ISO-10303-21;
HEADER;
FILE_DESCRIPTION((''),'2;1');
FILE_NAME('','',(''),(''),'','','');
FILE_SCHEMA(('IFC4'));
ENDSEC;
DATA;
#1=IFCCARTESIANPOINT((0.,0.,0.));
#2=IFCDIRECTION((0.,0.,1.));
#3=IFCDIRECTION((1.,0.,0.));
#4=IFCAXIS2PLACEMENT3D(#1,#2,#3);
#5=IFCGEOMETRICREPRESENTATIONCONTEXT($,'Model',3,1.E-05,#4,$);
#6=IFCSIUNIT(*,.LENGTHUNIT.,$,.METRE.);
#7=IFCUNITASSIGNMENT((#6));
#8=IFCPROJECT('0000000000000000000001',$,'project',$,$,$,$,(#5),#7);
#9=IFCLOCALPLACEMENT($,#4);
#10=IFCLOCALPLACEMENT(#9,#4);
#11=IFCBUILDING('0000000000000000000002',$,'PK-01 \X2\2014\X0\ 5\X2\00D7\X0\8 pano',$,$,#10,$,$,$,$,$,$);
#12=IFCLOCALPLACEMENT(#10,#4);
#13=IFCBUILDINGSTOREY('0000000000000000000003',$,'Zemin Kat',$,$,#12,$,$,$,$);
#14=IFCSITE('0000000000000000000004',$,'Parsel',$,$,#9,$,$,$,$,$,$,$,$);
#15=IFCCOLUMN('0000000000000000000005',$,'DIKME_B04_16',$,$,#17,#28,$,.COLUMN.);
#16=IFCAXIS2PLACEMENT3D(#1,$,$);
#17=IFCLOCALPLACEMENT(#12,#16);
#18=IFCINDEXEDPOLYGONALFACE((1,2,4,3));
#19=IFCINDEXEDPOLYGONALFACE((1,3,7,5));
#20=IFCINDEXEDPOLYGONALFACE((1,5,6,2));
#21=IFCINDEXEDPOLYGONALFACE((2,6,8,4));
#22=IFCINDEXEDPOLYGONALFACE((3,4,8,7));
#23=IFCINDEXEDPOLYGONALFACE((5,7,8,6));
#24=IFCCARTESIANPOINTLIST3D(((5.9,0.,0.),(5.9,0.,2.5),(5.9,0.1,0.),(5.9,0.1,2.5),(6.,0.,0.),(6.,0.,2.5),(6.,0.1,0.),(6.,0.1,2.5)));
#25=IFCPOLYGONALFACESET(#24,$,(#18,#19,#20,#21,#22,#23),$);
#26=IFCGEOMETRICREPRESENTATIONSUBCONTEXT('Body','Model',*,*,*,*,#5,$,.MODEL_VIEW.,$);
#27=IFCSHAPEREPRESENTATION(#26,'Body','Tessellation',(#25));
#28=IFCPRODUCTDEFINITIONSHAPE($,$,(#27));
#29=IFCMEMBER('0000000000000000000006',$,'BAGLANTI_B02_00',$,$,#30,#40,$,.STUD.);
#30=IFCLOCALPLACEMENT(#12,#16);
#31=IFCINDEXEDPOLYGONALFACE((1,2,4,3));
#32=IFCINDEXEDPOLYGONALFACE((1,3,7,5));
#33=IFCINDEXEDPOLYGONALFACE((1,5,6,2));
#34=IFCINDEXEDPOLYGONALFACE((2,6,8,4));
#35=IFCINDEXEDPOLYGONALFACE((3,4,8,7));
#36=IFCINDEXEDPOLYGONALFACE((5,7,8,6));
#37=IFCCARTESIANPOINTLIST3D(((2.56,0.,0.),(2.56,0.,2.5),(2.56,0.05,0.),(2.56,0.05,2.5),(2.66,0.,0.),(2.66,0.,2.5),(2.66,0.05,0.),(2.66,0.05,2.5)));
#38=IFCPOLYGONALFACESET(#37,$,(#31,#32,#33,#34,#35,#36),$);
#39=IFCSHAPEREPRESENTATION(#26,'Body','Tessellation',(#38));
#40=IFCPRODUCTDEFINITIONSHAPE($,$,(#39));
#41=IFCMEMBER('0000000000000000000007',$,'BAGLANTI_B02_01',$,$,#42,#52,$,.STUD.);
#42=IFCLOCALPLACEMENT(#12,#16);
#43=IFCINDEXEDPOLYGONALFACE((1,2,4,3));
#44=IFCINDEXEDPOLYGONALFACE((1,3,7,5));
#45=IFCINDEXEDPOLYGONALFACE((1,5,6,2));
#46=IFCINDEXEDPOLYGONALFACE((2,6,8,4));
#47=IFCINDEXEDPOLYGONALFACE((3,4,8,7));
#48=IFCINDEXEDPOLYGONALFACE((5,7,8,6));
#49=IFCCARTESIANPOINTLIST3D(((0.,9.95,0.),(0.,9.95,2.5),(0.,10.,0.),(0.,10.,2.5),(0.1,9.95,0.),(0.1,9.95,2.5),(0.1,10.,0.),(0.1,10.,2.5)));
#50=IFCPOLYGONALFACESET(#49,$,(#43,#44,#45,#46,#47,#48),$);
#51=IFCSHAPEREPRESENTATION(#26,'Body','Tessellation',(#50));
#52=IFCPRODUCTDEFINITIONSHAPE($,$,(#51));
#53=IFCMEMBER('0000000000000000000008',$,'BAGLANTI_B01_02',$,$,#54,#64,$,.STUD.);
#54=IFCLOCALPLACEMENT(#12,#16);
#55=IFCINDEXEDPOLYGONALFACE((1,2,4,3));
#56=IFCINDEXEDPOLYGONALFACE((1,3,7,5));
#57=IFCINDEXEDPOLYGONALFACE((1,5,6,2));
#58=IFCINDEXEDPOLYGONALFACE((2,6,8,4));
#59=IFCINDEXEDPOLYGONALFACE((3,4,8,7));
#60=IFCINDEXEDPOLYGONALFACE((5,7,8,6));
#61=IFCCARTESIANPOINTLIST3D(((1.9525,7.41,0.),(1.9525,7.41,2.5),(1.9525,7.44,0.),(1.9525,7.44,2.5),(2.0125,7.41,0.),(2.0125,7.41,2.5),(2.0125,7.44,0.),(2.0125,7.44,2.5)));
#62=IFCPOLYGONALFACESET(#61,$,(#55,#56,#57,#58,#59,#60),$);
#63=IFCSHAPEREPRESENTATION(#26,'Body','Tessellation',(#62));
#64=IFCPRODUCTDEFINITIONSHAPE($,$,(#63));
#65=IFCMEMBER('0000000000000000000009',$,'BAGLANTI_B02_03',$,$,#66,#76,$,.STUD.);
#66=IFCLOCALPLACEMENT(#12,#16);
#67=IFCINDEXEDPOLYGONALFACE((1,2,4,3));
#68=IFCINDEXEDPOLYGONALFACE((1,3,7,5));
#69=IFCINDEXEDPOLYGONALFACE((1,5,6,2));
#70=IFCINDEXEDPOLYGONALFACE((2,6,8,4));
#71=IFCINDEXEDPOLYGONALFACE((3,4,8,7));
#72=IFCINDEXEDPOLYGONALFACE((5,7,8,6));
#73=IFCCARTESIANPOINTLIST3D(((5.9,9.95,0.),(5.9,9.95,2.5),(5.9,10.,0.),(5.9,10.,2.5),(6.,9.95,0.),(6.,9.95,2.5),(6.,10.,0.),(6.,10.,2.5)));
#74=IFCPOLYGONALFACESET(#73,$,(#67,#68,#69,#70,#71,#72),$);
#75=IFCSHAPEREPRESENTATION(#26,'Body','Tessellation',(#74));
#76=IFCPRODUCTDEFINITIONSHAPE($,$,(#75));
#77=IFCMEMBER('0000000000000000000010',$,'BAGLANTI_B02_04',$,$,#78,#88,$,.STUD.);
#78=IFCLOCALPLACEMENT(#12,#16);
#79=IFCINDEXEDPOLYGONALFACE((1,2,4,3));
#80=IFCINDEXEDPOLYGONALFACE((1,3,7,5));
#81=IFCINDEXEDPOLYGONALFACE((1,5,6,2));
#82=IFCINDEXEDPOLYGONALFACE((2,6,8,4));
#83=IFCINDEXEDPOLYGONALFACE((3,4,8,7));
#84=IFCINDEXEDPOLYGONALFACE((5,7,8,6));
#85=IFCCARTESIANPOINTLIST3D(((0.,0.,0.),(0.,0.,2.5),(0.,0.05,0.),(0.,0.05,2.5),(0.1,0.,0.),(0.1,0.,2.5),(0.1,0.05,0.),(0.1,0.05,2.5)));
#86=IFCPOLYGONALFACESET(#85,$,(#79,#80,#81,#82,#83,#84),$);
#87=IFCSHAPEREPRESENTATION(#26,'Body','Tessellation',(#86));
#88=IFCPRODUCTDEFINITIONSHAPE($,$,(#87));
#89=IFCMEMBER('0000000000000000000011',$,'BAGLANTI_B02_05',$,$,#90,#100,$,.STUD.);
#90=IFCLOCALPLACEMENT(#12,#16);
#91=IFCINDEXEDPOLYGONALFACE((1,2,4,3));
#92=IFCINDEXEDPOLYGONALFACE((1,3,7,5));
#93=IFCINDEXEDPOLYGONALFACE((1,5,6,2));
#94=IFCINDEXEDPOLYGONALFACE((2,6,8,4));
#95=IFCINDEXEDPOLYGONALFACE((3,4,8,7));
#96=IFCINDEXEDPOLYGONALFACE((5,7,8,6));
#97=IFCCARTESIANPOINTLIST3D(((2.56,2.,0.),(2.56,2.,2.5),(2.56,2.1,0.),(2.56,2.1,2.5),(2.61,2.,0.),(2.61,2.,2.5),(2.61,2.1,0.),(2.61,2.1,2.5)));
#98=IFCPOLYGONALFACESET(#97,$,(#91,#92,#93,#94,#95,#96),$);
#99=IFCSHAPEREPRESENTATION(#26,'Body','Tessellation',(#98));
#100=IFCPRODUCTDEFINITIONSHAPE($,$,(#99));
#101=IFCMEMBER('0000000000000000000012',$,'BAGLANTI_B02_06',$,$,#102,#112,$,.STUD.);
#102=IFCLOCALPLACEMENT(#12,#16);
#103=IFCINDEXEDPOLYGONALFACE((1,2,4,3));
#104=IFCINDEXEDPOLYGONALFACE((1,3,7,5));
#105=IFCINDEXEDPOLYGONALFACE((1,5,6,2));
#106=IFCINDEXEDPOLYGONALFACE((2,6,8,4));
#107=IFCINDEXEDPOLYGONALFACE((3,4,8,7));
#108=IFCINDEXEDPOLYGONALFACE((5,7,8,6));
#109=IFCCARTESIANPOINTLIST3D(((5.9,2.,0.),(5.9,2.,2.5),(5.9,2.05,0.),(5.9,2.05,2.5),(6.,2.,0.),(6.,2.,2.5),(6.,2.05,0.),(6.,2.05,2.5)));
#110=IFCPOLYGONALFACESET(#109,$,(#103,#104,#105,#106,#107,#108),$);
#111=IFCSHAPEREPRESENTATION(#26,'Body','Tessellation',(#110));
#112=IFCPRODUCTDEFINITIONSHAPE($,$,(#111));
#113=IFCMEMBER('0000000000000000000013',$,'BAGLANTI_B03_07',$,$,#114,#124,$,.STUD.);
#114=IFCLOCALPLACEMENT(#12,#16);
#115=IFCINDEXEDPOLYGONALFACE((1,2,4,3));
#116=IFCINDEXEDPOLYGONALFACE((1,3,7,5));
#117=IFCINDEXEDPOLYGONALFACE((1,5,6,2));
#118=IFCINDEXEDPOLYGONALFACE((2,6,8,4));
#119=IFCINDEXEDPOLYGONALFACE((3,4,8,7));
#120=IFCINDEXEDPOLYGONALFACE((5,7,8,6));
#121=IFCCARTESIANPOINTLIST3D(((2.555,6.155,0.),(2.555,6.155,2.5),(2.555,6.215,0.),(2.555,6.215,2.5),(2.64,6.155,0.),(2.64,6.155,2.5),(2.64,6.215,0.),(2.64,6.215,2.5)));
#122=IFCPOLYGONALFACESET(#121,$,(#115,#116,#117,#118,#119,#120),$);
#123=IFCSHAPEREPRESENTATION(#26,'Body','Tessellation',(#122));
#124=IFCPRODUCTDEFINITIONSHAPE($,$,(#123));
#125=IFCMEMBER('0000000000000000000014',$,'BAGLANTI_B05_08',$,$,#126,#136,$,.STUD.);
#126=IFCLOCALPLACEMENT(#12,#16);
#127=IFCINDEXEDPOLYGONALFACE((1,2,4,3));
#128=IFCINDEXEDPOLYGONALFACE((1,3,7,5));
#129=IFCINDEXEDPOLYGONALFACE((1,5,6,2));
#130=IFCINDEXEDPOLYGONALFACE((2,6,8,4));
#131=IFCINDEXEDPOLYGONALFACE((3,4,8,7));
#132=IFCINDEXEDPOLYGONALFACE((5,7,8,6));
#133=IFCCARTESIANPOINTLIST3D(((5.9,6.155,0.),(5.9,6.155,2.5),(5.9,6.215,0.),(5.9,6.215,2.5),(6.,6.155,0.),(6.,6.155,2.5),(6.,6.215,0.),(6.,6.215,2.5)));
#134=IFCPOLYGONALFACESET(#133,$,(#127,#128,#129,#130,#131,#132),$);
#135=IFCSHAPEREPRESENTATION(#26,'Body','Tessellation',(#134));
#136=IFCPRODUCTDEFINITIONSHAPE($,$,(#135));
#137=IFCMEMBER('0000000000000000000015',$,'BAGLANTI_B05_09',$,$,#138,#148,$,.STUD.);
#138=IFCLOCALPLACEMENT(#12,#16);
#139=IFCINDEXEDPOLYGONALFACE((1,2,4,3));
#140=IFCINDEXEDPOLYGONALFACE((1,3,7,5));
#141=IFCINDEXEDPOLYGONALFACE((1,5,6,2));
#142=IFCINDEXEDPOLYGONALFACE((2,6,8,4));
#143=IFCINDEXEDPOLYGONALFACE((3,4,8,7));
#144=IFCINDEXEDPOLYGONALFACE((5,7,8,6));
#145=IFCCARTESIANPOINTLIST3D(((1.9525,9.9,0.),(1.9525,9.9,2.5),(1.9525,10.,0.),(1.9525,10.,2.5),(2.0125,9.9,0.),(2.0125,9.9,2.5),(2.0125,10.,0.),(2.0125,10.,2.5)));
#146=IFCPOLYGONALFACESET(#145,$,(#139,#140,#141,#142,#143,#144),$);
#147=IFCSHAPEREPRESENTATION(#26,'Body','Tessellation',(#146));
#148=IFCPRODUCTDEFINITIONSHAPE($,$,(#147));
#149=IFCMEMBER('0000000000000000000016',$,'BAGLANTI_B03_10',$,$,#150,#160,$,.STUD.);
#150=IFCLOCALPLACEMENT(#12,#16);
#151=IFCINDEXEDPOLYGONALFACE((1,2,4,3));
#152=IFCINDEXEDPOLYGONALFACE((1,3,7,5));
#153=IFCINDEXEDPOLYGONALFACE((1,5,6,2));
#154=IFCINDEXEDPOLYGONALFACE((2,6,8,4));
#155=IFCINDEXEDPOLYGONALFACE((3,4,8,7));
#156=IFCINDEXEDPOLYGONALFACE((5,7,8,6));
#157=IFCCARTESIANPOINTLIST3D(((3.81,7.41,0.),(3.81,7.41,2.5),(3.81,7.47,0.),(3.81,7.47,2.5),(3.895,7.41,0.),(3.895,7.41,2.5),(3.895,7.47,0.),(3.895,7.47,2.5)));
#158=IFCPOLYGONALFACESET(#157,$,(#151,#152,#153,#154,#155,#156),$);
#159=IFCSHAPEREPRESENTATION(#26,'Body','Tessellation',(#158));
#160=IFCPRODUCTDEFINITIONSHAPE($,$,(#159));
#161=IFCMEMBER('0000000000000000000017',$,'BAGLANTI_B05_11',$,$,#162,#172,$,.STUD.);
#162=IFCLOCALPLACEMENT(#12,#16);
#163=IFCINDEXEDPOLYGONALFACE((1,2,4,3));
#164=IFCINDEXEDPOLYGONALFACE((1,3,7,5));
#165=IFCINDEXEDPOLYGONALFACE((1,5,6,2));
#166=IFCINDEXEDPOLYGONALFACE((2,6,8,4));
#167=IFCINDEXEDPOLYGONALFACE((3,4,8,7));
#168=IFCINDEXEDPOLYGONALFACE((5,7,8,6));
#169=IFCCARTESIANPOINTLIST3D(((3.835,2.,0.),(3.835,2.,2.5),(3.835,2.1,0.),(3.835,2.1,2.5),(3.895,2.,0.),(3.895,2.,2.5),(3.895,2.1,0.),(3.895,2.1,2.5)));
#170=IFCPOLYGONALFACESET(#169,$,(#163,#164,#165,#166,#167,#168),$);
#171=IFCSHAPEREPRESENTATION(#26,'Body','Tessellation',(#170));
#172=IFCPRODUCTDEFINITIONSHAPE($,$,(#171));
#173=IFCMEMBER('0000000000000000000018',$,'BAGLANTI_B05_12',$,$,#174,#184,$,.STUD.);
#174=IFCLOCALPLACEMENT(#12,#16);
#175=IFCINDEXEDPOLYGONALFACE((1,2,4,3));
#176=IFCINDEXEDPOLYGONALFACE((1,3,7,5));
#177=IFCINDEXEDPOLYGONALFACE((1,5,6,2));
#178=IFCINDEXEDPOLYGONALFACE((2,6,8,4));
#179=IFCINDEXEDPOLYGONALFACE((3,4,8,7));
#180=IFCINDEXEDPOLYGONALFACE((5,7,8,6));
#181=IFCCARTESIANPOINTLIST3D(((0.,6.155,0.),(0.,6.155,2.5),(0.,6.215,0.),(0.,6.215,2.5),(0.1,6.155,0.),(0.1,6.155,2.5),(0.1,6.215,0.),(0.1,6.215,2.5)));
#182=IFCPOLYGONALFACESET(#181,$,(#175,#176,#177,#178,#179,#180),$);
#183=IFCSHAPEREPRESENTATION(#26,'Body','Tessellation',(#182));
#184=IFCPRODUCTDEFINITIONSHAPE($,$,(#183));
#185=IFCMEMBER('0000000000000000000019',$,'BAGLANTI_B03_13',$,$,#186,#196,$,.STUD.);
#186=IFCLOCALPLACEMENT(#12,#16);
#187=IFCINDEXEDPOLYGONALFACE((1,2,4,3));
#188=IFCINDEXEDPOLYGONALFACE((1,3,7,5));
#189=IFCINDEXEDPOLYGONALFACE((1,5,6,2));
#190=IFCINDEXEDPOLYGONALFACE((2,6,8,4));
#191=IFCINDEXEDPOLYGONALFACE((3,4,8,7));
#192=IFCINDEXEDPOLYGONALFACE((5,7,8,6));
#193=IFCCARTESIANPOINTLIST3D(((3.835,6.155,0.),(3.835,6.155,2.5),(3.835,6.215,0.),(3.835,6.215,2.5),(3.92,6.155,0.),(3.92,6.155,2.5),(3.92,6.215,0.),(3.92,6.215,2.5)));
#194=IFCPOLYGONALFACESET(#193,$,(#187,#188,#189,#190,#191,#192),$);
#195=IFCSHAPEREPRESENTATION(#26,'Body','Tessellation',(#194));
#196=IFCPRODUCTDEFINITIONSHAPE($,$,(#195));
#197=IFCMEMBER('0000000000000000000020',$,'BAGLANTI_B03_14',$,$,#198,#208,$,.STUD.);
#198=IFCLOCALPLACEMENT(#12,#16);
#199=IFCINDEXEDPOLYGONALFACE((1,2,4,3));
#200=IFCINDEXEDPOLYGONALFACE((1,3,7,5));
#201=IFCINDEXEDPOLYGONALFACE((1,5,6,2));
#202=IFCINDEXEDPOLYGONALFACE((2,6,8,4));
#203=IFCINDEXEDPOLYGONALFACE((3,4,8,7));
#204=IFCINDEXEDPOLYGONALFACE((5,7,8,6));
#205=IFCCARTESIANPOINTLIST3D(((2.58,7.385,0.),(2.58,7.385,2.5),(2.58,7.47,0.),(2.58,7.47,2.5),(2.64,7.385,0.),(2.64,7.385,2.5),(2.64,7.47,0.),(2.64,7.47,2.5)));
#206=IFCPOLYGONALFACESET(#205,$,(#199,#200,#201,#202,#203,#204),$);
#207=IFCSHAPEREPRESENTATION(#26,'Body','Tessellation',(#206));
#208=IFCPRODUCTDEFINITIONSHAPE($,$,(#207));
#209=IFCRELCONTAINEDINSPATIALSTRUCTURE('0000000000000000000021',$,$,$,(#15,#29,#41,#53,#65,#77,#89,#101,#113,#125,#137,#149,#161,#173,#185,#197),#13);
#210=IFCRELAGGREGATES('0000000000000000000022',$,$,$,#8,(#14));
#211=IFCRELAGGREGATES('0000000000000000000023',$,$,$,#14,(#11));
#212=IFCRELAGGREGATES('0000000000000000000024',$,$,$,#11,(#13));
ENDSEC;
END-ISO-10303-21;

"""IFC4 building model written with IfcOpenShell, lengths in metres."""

from ifc_helpers import new_model, si_unit, origin_with_axes, place, context, subcontext, project, spatial, line, indexed_curve, outline, extrude, element, save


model = new_model("IFC4")

# Units and contexts
model_context = context("Model", 3, precision=1e-05, world=origin_with_axes())
body_context = subcontext(model_context, "Body", "Model", "MODEL_VIEW")
ifc_project = project(units=[si_unit("LENGTHUNIT", "METRE")], contexts=[model_context])

# Site, building, storey
site_placement = place(None, origin_with_axes())
site = spatial("IfcSite", under=ifc_project, at=site_placement, Name="Parsel")
building_placement = place(site_placement, origin_with_axes())
building = spatial("IfcBuilding", under=site, at=building_placement, Name="PK-01 — 5×8 pano")
storey_placement = place(building_placement, origin_with_axes())
storey = spatial("IfcBuildingStorey", under=building, at=storey_placement, Name="Zemin Kat")

# Column
column_placement = place(storey_placement, origin_with_axes())
element("IfcColumn", 1, at=column_placement, inside=storey, Name="DIKME_B04_16", PredefinedType="COLUMN", context=body_context, shape_type="SweptSolid", body=[
    extrude(outline(indexed_curve([(5.9, 0.0), (6.0, 0.0), (6.0, 0.1), (5.9, 0.1)], segments=[line(1, 2, 3, 4, 1)])), origin_with_axes(), (0.0, 0.0, 1.0), 2.5),
])

# Members
member_1_placement = place(storey_placement, origin_with_axes())
element("IfcMember", 2, at=member_1_placement, inside=storey, Name="BAGLANTI_B02_00", PredefinedType="STUD", context=body_context, shape_type="SweptSolid", body=[
    extrude(outline(indexed_curve([(2.56, 0.0), (2.66, 0.0), (2.66, 0.05), (2.56, 0.05)], segments=[line(1, 2, 3, 4, 1)])), origin_with_axes(), (0.0, 0.0, 1.0), 2.5),
])
member_2_placement = place(storey_placement, origin_with_axes())
element("IfcMember", 3, at=member_2_placement, inside=storey, Name="BAGLANTI_B02_01", PredefinedType="STUD", context=body_context, shape_type="SweptSolid", body=[
    extrude(outline(indexed_curve([(0.0, 9.95), (0.1, 9.95), (0.1, 10.0), (0.0, 10.0)], segments=[line(1, 2, 3, 4, 1)])), origin_with_axes(), (0.0, 0.0, 1.0), 2.5),
])
member_3_placement = place(storey_placement, origin_with_axes())
element("IfcMember", 4, at=member_3_placement, inside=storey, Name="BAGLANTI_B01_02", PredefinedType="STUD", context=body_context, shape_type="SweptSolid", body=[
    extrude(outline(indexed_curve([(1.9525, 7.41), (2.0125, 7.41), (2.0125, 7.44), (1.9525, 7.44)], segments=[line(1, 2, 3, 4, 1)])), origin_with_axes(), (0.0, 0.0, 1.0), 2.5),
])
member_4_placement = place(storey_placement, origin_with_axes())
element("IfcMember", 5, at=member_4_placement, inside=storey, Name="BAGLANTI_B02_03", PredefinedType="STUD", context=body_context, shape_type="SweptSolid", body=[
    extrude(outline(indexed_curve([(5.9, 9.95), (6.0, 9.95), (6.0, 10.0), (5.9, 10.0)], segments=[line(1, 2, 3, 4, 1)])), origin_with_axes(), (0.0, 0.0, 1.0), 2.5),
])
member_5_placement = place(storey_placement, origin_with_axes())
element("IfcMember", 6, at=member_5_placement, inside=storey, Name="BAGLANTI_B02_04", PredefinedType="STUD", context=body_context, shape_type="SweptSolid", body=[
    extrude(outline(indexed_curve([(0.0, 0.0), (0.1, 0.0), (0.1, 0.05), (0.0, 0.05)], segments=[line(1, 2, 3, 4, 1)])), origin_with_axes(), (0.0, 0.0, 1.0), 2.5),
])
member_6_placement = place(storey_placement, origin_with_axes())
element("IfcMember", 7, at=member_6_placement, inside=storey, Name="BAGLANTI_B02_05", PredefinedType="STUD", context=body_context, shape_type="SweptSolid", body=[
    extrude(outline(indexed_curve([(2.56, 2.0), (2.61, 2.0), (2.61, 2.1), (2.56, 2.1)], segments=[line(1, 2, 3, 4, 1)])), origin_with_axes(), (0.0, 0.0, 1.0), 2.5),
])
member_7_placement = place(storey_placement, origin_with_axes())
element("IfcMember", 8, at=member_7_placement, inside=storey, Name="BAGLANTI_B02_06", PredefinedType="STUD", context=body_context, shape_type="SweptSolid", body=[
    extrude(outline(indexed_curve([(5.9, 2.0), (6.0, 2.0), (6.0, 2.05), (5.9, 2.05)], segments=[line(1, 2, 3, 4, 1)])), origin_with_axes(), (0.0, 0.0, 1.0), 2.5),
])
member_8_placement = place(storey_placement, origin_with_axes())
element("IfcMember", 9, at=member_8_placement, inside=storey, Name="BAGLANTI_B03_07", PredefinedType="STUD", context=body_context, shape_type="SweptSolid", body=[
    extrude(outline(indexed_curve([(2.555, 6.155), (2.64, 6.155), (2.64, 6.215), (2.555, 6.215)], segments=[line(1, 2, 3, 4, 1)])), origin_with_axes(), (0.0, 0.0, 1.0), 2.5),
])
member_9_placement = place(storey_placement, origin_with_axes())
element("IfcMember", 10, at=member_9_placement, inside=storey, Name="BAGLANTI_B05_08", PredefinedType="STUD", context=body_context, shape_type="SweptSolid", body=[
    extrude(outline(indexed_curve([(5.9, 6.155), (6.0, 6.155), (6.0, 6.215), (5.9, 6.215)], segments=[line(1, 2, 3, 4, 1)])), origin_with_axes(), (0.0, 0.0, 1.0), 2.5),
])
member_10_placement = place(storey_placement, origin_with_axes())
element("IfcMember", 11, at=member_10_placement, inside=storey, Name="BAGLANTI_B05_09", PredefinedType="STUD", context=body_context, shape_type="SweptSolid", body=[
    extrude(outline(indexed_curve([(1.9525, 9.9), (2.0125, 9.9), (2.0125, 10.0), (1.9525, 10.0)], segments=[line(1, 2, 3, 4, 1)])), origin_with_axes(), (0.0, 0.0, 1.0), 2.5),
])
member_11_placement = place(storey_placement, origin_with_axes())
element("IfcMember", 12, at=member_11_placement, inside=storey, Name="BAGLANTI_B03_10", PredefinedType="STUD", context=body_context, shape_type="SweptSolid", body=[
    extrude(outline(indexed_curve([(3.81, 7.41), (3.895, 7.41), (3.895, 7.47), (3.81, 7.47)], segments=[line(1, 2, 3, 4, 1)])), origin_with_axes(), (0.0, 0.0, 1.0), 2.5),
])
member_12_placement = place(storey_placement, origin_with_axes())
element("IfcMember", 13, at=member_12_placement, inside=storey, Name="BAGLANTI_B05_11", PredefinedType="STUD", context=body_context, shape_type="SweptSolid", body=[
    extrude(outline(indexed_curve([(3.835, 2.0), (3.895, 2.0), (3.895, 2.1), (3.835, 2.1)], segments=[line(1, 2, 3, 4, 1)])), origin_with_axes(), (0.0, 0.0, 1.0), 2.5),
])
member_13_placement = place(storey_placement, origin_with_axes())
element("IfcMember", 14, at=member_13_placement, inside=storey, Name="BAGLANTI_B05_12", PredefinedType="STUD", context=body_context, shape_type="SweptSolid", body=[
    extrude(outline(indexed_curve([(0.0, 6.155), (0.1, 6.155), (0.1, 6.215), (0.0, 6.215)], segments=[line(1, 2, 3, 4, 1)])), origin_with_axes(), (0.0, 0.0, 1.0), 2.5),
])
member_14_placement = place(storey_placement, origin_with_axes())
element("IfcMember", 15, at=member_14_placement, inside=storey, Name="BAGLANTI_B03_13", PredefinedType="STUD", context=body_context, shape_type="SweptSolid", body=[
    extrude(outline(indexed_curve([(3.835, 6.155), (3.92, 6.155), (3.92, 6.215), (3.835, 6.215)], segments=[line(1, 2, 3, 4, 1)])), origin_with_axes(), (0.0, 0.0, 1.0), 2.5),
])
member_15_placement = place(storey_placement, origin_with_axes())
element("IfcMember", 16, at=member_15_placement, inside=storey, Name="BAGLANTI_B03_14", PredefinedType="STUD", context=body_context, shape_type="SweptSolid", body=[
    extrude(outline(indexed_curve([(2.58, 7.385), (2.64, 7.385), (2.64, 7.47), (2.58, 7.47)], segments=[line(1, 2, 3, 4, 1)])), origin_with_axes(), (0.0, 0.0, 1.0), 2.5),
])

save(model, "model.ifc")
